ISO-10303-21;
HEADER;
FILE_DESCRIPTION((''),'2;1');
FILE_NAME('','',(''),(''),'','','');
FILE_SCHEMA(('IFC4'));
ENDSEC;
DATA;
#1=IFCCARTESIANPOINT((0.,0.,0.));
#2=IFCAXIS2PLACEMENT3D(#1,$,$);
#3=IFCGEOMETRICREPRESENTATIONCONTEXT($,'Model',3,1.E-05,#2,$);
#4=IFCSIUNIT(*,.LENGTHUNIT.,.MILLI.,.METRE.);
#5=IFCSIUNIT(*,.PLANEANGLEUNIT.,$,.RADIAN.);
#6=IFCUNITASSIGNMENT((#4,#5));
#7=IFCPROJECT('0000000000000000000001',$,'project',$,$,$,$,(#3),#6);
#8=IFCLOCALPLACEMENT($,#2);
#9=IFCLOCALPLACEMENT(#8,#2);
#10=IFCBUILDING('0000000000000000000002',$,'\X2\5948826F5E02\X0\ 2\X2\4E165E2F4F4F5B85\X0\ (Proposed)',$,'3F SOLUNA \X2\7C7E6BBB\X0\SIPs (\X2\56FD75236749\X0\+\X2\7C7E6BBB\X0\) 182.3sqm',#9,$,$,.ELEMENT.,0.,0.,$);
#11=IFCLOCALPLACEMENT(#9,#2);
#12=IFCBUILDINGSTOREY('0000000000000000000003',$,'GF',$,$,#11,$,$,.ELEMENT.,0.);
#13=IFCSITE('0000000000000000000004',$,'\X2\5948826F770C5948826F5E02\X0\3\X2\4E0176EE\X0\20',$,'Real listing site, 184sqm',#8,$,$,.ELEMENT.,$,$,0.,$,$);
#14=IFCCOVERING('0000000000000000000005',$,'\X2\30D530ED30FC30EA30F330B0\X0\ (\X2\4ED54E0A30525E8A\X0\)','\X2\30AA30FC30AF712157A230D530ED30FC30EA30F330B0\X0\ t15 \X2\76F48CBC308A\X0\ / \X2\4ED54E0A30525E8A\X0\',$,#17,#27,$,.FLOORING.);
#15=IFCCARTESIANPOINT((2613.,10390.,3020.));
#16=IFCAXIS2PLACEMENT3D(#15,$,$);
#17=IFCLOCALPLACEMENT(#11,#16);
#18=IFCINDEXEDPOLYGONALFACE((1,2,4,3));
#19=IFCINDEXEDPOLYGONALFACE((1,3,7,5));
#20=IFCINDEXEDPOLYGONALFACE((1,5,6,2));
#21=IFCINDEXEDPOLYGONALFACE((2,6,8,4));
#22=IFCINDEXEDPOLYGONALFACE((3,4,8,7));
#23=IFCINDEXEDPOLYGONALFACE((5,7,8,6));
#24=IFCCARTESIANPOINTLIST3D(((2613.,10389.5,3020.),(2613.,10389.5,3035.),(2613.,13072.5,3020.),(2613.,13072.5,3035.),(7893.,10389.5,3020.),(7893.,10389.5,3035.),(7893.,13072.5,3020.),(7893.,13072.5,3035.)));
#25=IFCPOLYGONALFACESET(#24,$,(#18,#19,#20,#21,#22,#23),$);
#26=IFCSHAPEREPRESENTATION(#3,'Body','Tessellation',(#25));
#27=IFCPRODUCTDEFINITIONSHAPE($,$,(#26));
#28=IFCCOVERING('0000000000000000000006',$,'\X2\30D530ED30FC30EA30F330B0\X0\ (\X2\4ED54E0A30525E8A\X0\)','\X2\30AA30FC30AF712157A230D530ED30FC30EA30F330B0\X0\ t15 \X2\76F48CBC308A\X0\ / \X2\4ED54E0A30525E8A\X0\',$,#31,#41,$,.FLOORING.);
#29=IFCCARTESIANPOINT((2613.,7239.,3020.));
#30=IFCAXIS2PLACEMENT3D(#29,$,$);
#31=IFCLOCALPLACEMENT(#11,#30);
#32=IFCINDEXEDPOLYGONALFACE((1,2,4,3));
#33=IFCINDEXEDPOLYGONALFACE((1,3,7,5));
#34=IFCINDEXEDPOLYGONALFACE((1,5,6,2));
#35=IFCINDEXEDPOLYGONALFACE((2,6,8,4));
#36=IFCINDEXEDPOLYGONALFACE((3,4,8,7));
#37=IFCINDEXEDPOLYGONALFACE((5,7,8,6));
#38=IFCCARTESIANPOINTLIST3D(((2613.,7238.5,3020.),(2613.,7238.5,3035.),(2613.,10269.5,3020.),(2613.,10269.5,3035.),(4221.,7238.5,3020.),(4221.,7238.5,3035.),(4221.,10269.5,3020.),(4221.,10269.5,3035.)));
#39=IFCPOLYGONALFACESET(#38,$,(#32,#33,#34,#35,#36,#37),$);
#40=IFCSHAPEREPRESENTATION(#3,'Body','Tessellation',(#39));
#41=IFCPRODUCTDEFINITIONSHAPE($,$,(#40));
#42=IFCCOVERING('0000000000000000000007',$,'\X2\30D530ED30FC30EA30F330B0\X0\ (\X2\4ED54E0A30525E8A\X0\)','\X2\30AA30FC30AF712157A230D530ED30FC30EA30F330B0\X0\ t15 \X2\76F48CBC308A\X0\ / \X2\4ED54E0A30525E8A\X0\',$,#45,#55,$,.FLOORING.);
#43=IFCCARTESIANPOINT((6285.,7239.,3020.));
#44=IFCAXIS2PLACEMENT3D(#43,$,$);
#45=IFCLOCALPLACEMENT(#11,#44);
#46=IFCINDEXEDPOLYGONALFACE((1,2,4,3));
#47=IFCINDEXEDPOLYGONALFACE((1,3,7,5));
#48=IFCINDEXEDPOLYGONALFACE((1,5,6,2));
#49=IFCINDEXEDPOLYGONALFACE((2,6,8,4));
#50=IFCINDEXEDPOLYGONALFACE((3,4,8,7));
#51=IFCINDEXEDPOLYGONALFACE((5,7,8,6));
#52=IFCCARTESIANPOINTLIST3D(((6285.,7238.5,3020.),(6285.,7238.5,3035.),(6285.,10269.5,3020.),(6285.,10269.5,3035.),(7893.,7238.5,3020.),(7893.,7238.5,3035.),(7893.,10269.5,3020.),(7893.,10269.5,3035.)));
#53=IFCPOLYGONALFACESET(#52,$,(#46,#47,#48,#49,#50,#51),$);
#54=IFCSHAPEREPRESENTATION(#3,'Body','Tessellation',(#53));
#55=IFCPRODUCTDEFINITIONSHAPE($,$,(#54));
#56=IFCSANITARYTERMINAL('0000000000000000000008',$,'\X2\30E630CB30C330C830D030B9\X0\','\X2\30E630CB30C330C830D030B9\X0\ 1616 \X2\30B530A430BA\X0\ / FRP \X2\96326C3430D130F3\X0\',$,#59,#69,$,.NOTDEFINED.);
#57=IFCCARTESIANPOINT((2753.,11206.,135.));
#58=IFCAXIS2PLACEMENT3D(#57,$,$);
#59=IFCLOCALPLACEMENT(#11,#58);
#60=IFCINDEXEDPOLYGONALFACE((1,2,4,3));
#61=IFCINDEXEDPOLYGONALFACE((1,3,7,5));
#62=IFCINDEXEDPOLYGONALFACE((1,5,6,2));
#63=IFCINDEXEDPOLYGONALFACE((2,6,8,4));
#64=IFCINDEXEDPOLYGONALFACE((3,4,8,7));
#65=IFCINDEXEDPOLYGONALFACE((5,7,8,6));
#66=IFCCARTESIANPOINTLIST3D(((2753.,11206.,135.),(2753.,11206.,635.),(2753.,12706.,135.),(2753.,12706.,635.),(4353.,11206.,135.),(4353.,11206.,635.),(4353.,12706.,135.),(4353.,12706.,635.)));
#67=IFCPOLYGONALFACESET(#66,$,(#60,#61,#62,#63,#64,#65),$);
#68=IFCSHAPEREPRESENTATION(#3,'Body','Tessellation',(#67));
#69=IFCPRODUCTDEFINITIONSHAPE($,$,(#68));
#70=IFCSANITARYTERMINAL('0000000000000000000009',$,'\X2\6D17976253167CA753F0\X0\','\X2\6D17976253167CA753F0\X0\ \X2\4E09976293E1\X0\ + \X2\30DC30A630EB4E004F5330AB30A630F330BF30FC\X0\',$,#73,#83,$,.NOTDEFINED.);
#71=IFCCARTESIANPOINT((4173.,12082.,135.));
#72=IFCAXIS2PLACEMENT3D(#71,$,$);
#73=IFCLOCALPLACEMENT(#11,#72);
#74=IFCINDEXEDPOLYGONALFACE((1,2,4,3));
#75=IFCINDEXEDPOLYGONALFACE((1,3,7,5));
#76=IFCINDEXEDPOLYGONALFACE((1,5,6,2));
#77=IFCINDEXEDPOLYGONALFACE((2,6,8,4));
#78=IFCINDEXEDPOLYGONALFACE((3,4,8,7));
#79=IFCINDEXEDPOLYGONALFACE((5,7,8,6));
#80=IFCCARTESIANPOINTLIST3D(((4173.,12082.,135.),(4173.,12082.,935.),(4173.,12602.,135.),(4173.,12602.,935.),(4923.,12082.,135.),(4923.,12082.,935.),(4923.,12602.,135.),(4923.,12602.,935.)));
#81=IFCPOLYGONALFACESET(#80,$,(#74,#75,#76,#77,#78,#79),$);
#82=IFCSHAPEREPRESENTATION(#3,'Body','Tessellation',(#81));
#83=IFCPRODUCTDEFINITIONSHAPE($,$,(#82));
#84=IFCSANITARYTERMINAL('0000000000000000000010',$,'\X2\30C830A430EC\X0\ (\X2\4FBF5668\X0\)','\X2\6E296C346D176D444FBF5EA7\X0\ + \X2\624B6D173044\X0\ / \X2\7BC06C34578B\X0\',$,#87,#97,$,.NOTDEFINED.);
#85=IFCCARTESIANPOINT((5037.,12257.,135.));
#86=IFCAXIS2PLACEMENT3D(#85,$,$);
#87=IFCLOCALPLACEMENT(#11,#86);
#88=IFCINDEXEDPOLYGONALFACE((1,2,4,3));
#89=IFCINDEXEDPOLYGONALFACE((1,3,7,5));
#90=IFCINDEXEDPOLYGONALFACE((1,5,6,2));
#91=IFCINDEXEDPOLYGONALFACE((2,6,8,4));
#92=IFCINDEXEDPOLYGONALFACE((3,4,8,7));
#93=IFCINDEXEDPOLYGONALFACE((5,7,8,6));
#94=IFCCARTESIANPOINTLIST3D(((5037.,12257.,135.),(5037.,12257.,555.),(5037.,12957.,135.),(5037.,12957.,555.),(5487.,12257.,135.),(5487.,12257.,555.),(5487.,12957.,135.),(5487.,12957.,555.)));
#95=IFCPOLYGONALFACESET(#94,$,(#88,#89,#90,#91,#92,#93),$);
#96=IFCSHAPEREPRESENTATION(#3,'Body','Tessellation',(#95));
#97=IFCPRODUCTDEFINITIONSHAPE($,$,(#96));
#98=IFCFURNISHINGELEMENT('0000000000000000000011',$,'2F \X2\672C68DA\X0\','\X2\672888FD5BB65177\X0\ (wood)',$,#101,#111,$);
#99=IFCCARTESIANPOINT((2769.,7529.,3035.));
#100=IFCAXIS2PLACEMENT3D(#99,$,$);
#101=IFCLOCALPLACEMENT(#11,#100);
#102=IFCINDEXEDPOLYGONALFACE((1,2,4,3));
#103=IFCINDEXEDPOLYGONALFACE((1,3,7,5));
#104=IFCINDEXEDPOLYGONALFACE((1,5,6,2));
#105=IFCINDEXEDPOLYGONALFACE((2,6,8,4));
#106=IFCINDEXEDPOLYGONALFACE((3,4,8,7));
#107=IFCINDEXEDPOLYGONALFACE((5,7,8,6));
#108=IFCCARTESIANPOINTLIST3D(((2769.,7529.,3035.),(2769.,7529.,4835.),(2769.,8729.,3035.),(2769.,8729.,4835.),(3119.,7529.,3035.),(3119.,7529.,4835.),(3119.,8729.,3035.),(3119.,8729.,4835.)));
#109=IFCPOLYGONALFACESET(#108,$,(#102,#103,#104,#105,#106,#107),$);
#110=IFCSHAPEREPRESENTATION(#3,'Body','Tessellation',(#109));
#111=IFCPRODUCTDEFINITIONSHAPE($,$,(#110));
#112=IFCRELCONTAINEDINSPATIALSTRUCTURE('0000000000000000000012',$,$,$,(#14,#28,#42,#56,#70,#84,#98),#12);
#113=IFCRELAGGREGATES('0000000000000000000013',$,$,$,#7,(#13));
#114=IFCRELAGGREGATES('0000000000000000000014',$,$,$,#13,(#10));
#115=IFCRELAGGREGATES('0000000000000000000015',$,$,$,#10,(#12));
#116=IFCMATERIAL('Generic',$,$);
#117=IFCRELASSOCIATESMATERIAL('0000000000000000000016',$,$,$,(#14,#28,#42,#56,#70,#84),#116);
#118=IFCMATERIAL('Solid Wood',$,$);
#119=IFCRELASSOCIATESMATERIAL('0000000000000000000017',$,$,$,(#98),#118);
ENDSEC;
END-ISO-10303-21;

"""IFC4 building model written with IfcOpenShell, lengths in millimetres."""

from ifc_helpers import new_model, si_unit, frame, frame_2d, origin, place, context, project, spatial, rectangle, extrude, material, element, save


model = new_model("IFC4")

# Units and contexts
model_context = context("Model", 3, precision=1e-05, world=origin())
ifc_project = project(units=[si_unit("LENGTHUNIT", "METRE", prefix="MILLI"), si_unit("PLANEANGLEUNIT", "RADIAN")], contexts=[model_context])

# Site, building, storey
site_placement = place(None, origin())
site = spatial("IfcSite", under=ifc_project, at=site_placement, Name="奈良県奈良市3丁目20", ObjectType="Real listing site, 184sqm", CompositionType="ELEMENT", RefElevation=0.0)
building_placement = place(site_placement, origin())
building = spatial("IfcBuilding", under=site, at=building_placement, Name="奈良市 2世帯住宅 (Proposed)", ObjectType="3F SOLUNA 籾殻SIPs (国産杉+籾殻) 182.3sqm", CompositionType="ELEMENT", ElevationOfRefHeight=0.0, ElevationOfTerrain=0.0)
storey_placement = place(building_placement, origin())
storey = spatial("IfcBuildingStorey", under=building, at=storey_placement, Name="GF", CompositionType="ELEMENT", Elevation=0.0)

# Shared definitions
ifc_material_1 = material(Name="Solid Wood")

# Coverings
ifc_material_2 = material(Name="Generic")
covering_1_placement = place(storey_placement, frame((2613.0, 10390.0, 3020.0)))
element("IfcCovering", 1, at=covering_1_placement, inside=storey, material=ifc_material_2, Name="フローリング (仕上げ床)", Description="オーク無垢フローリング t15 直貼り / 仕上げ床", PredefinedType="FLOORING", context=model_context, shape_type="SweptSolid", body=[
    extrude(rectangle(XDim=5280.0, YDim=2683.0, at=frame_2d((2640.0, 1341.0))), frame((2613.0, 10390.0, 3020.0)), (0.0, 0.0, 1.0), 15.0),
])
covering_2_placement = place(storey_placement, frame((2613.0, 7239.0, 3020.0)))
element("IfcCovering", 2, at=covering_2_placement, inside=storey, material=ifc_material_2, Name="フローリング (仕上げ床)", Description="オーク無垢フローリング t15 直貼り / 仕上げ床", PredefinedType="FLOORING", context=model_context, shape_type="SweptSolid", body=[
    extrude(rectangle(XDim=1608.0, YDim=3031.0, at=frame_2d((804.0, 1515.0))), frame((2613.0, 7239.0, 3020.0)), (0.0, 0.0, 1.0), 15.0),
])
covering_3_placement = place(storey_placement, frame((6285.0, 7239.0, 3020.0)))
element("IfcCovering", 3, at=covering_3_placement, inside=storey, material=ifc_material_2, Name="フローリング (仕上げ床)", Description="オーク無垢フローリング t15 直貼り / 仕上げ床", PredefinedType="FLOORING", context=model_context, shape_type="SweptSolid", body=[
    extrude(rectangle(XDim=1608.0, YDim=3031.0, at=frame_2d((804.0, 1515.0))), frame((6285.0, 7239.0, 3020.0)), (0.0, 0.0, 1.0), 15.0),
])

# Sanitary terminals
sanitary_terminal_1_placement = place(storey_placement, frame((2753.0, 11206.0, 135.0)))
element("IfcSanitaryTerminal", 4, at=sanitary_terminal_1_placement, inside=storey, material=ifc_material_2, Name="ユニットバス", Description="ユニットバス 1616 サイズ / FRP 防水パン", PredefinedType="NOTDEFINED", context=model_context, shape_type="SweptSolid", body=[
    extrude(rectangle(XDim=1600.0, YDim=1500.0, at=frame_2d((800.0, 750.0))), frame((2753.0, 11206.0, 135.0)), (0.0, 0.0, 1.0), 500.0),
])
sanitary_terminal_2_placement = place(storey_placement, frame((4173.0, 12082.0, 135.0)))
element("IfcSanitaryTerminal", 5, at=sanitary_terminal_2_placement, inside=storey, material=ifc_material_2, Name="洗面化粧台", Description="洗面化粧台 三面鏡 + ボウル一体カウンター", PredefinedType="NOTDEFINED", context=model_context, shape_type="SweptSolid", body=[
    extrude(rectangle(XDim=750.0, YDim=520.0, at=frame_2d((375.0, 260.0))), frame((4173.0, 12082.0, 135.0)), (0.0, 0.0, 1.0), 800.0),
])
sanitary_terminal_3_placement = place(storey_placement, frame((5037.0, 12257.0, 135.0)))
element("IfcSanitaryTerminal", 6, at=sanitary_terminal_3_placement, inside=storey, material=ifc_material_2, Name="トイレ (便器)", Description="温水洗浄便座 + 手洗い / 節水型", PredefinedType="NOTDEFINED", context=model_context, shape_type="SweptSolid", body=[
    extrude(rectangle(XDim=450.0, YDim=700.0, at=frame_2d((225.0, 350.0))), frame((5037.0, 12257.0, 135.0)), (0.0, 0.0, 1.0), 420.0),
])

# Furnishing element
furnishing_placement = place(storey_placement, frame((2769.0, 7529.0, 3035.0)))
element("IfcFurnishingElement", 7, at=furnishing_placement, inside=storey, material=ifc_material_1, Name="2F 本棚", Description="木製家具 (wood)", context=model_context, shape_type="SweptSolid", body=[
    extrude(rectangle(XDim=350.0, YDim=1200.0, at=frame_2d((175.0, 600.0))), frame((2769.0, 7529.0, 3035.0)), (0.0, 0.0, 1.0), 1800.0),
])

save(model, "model.ifc")
